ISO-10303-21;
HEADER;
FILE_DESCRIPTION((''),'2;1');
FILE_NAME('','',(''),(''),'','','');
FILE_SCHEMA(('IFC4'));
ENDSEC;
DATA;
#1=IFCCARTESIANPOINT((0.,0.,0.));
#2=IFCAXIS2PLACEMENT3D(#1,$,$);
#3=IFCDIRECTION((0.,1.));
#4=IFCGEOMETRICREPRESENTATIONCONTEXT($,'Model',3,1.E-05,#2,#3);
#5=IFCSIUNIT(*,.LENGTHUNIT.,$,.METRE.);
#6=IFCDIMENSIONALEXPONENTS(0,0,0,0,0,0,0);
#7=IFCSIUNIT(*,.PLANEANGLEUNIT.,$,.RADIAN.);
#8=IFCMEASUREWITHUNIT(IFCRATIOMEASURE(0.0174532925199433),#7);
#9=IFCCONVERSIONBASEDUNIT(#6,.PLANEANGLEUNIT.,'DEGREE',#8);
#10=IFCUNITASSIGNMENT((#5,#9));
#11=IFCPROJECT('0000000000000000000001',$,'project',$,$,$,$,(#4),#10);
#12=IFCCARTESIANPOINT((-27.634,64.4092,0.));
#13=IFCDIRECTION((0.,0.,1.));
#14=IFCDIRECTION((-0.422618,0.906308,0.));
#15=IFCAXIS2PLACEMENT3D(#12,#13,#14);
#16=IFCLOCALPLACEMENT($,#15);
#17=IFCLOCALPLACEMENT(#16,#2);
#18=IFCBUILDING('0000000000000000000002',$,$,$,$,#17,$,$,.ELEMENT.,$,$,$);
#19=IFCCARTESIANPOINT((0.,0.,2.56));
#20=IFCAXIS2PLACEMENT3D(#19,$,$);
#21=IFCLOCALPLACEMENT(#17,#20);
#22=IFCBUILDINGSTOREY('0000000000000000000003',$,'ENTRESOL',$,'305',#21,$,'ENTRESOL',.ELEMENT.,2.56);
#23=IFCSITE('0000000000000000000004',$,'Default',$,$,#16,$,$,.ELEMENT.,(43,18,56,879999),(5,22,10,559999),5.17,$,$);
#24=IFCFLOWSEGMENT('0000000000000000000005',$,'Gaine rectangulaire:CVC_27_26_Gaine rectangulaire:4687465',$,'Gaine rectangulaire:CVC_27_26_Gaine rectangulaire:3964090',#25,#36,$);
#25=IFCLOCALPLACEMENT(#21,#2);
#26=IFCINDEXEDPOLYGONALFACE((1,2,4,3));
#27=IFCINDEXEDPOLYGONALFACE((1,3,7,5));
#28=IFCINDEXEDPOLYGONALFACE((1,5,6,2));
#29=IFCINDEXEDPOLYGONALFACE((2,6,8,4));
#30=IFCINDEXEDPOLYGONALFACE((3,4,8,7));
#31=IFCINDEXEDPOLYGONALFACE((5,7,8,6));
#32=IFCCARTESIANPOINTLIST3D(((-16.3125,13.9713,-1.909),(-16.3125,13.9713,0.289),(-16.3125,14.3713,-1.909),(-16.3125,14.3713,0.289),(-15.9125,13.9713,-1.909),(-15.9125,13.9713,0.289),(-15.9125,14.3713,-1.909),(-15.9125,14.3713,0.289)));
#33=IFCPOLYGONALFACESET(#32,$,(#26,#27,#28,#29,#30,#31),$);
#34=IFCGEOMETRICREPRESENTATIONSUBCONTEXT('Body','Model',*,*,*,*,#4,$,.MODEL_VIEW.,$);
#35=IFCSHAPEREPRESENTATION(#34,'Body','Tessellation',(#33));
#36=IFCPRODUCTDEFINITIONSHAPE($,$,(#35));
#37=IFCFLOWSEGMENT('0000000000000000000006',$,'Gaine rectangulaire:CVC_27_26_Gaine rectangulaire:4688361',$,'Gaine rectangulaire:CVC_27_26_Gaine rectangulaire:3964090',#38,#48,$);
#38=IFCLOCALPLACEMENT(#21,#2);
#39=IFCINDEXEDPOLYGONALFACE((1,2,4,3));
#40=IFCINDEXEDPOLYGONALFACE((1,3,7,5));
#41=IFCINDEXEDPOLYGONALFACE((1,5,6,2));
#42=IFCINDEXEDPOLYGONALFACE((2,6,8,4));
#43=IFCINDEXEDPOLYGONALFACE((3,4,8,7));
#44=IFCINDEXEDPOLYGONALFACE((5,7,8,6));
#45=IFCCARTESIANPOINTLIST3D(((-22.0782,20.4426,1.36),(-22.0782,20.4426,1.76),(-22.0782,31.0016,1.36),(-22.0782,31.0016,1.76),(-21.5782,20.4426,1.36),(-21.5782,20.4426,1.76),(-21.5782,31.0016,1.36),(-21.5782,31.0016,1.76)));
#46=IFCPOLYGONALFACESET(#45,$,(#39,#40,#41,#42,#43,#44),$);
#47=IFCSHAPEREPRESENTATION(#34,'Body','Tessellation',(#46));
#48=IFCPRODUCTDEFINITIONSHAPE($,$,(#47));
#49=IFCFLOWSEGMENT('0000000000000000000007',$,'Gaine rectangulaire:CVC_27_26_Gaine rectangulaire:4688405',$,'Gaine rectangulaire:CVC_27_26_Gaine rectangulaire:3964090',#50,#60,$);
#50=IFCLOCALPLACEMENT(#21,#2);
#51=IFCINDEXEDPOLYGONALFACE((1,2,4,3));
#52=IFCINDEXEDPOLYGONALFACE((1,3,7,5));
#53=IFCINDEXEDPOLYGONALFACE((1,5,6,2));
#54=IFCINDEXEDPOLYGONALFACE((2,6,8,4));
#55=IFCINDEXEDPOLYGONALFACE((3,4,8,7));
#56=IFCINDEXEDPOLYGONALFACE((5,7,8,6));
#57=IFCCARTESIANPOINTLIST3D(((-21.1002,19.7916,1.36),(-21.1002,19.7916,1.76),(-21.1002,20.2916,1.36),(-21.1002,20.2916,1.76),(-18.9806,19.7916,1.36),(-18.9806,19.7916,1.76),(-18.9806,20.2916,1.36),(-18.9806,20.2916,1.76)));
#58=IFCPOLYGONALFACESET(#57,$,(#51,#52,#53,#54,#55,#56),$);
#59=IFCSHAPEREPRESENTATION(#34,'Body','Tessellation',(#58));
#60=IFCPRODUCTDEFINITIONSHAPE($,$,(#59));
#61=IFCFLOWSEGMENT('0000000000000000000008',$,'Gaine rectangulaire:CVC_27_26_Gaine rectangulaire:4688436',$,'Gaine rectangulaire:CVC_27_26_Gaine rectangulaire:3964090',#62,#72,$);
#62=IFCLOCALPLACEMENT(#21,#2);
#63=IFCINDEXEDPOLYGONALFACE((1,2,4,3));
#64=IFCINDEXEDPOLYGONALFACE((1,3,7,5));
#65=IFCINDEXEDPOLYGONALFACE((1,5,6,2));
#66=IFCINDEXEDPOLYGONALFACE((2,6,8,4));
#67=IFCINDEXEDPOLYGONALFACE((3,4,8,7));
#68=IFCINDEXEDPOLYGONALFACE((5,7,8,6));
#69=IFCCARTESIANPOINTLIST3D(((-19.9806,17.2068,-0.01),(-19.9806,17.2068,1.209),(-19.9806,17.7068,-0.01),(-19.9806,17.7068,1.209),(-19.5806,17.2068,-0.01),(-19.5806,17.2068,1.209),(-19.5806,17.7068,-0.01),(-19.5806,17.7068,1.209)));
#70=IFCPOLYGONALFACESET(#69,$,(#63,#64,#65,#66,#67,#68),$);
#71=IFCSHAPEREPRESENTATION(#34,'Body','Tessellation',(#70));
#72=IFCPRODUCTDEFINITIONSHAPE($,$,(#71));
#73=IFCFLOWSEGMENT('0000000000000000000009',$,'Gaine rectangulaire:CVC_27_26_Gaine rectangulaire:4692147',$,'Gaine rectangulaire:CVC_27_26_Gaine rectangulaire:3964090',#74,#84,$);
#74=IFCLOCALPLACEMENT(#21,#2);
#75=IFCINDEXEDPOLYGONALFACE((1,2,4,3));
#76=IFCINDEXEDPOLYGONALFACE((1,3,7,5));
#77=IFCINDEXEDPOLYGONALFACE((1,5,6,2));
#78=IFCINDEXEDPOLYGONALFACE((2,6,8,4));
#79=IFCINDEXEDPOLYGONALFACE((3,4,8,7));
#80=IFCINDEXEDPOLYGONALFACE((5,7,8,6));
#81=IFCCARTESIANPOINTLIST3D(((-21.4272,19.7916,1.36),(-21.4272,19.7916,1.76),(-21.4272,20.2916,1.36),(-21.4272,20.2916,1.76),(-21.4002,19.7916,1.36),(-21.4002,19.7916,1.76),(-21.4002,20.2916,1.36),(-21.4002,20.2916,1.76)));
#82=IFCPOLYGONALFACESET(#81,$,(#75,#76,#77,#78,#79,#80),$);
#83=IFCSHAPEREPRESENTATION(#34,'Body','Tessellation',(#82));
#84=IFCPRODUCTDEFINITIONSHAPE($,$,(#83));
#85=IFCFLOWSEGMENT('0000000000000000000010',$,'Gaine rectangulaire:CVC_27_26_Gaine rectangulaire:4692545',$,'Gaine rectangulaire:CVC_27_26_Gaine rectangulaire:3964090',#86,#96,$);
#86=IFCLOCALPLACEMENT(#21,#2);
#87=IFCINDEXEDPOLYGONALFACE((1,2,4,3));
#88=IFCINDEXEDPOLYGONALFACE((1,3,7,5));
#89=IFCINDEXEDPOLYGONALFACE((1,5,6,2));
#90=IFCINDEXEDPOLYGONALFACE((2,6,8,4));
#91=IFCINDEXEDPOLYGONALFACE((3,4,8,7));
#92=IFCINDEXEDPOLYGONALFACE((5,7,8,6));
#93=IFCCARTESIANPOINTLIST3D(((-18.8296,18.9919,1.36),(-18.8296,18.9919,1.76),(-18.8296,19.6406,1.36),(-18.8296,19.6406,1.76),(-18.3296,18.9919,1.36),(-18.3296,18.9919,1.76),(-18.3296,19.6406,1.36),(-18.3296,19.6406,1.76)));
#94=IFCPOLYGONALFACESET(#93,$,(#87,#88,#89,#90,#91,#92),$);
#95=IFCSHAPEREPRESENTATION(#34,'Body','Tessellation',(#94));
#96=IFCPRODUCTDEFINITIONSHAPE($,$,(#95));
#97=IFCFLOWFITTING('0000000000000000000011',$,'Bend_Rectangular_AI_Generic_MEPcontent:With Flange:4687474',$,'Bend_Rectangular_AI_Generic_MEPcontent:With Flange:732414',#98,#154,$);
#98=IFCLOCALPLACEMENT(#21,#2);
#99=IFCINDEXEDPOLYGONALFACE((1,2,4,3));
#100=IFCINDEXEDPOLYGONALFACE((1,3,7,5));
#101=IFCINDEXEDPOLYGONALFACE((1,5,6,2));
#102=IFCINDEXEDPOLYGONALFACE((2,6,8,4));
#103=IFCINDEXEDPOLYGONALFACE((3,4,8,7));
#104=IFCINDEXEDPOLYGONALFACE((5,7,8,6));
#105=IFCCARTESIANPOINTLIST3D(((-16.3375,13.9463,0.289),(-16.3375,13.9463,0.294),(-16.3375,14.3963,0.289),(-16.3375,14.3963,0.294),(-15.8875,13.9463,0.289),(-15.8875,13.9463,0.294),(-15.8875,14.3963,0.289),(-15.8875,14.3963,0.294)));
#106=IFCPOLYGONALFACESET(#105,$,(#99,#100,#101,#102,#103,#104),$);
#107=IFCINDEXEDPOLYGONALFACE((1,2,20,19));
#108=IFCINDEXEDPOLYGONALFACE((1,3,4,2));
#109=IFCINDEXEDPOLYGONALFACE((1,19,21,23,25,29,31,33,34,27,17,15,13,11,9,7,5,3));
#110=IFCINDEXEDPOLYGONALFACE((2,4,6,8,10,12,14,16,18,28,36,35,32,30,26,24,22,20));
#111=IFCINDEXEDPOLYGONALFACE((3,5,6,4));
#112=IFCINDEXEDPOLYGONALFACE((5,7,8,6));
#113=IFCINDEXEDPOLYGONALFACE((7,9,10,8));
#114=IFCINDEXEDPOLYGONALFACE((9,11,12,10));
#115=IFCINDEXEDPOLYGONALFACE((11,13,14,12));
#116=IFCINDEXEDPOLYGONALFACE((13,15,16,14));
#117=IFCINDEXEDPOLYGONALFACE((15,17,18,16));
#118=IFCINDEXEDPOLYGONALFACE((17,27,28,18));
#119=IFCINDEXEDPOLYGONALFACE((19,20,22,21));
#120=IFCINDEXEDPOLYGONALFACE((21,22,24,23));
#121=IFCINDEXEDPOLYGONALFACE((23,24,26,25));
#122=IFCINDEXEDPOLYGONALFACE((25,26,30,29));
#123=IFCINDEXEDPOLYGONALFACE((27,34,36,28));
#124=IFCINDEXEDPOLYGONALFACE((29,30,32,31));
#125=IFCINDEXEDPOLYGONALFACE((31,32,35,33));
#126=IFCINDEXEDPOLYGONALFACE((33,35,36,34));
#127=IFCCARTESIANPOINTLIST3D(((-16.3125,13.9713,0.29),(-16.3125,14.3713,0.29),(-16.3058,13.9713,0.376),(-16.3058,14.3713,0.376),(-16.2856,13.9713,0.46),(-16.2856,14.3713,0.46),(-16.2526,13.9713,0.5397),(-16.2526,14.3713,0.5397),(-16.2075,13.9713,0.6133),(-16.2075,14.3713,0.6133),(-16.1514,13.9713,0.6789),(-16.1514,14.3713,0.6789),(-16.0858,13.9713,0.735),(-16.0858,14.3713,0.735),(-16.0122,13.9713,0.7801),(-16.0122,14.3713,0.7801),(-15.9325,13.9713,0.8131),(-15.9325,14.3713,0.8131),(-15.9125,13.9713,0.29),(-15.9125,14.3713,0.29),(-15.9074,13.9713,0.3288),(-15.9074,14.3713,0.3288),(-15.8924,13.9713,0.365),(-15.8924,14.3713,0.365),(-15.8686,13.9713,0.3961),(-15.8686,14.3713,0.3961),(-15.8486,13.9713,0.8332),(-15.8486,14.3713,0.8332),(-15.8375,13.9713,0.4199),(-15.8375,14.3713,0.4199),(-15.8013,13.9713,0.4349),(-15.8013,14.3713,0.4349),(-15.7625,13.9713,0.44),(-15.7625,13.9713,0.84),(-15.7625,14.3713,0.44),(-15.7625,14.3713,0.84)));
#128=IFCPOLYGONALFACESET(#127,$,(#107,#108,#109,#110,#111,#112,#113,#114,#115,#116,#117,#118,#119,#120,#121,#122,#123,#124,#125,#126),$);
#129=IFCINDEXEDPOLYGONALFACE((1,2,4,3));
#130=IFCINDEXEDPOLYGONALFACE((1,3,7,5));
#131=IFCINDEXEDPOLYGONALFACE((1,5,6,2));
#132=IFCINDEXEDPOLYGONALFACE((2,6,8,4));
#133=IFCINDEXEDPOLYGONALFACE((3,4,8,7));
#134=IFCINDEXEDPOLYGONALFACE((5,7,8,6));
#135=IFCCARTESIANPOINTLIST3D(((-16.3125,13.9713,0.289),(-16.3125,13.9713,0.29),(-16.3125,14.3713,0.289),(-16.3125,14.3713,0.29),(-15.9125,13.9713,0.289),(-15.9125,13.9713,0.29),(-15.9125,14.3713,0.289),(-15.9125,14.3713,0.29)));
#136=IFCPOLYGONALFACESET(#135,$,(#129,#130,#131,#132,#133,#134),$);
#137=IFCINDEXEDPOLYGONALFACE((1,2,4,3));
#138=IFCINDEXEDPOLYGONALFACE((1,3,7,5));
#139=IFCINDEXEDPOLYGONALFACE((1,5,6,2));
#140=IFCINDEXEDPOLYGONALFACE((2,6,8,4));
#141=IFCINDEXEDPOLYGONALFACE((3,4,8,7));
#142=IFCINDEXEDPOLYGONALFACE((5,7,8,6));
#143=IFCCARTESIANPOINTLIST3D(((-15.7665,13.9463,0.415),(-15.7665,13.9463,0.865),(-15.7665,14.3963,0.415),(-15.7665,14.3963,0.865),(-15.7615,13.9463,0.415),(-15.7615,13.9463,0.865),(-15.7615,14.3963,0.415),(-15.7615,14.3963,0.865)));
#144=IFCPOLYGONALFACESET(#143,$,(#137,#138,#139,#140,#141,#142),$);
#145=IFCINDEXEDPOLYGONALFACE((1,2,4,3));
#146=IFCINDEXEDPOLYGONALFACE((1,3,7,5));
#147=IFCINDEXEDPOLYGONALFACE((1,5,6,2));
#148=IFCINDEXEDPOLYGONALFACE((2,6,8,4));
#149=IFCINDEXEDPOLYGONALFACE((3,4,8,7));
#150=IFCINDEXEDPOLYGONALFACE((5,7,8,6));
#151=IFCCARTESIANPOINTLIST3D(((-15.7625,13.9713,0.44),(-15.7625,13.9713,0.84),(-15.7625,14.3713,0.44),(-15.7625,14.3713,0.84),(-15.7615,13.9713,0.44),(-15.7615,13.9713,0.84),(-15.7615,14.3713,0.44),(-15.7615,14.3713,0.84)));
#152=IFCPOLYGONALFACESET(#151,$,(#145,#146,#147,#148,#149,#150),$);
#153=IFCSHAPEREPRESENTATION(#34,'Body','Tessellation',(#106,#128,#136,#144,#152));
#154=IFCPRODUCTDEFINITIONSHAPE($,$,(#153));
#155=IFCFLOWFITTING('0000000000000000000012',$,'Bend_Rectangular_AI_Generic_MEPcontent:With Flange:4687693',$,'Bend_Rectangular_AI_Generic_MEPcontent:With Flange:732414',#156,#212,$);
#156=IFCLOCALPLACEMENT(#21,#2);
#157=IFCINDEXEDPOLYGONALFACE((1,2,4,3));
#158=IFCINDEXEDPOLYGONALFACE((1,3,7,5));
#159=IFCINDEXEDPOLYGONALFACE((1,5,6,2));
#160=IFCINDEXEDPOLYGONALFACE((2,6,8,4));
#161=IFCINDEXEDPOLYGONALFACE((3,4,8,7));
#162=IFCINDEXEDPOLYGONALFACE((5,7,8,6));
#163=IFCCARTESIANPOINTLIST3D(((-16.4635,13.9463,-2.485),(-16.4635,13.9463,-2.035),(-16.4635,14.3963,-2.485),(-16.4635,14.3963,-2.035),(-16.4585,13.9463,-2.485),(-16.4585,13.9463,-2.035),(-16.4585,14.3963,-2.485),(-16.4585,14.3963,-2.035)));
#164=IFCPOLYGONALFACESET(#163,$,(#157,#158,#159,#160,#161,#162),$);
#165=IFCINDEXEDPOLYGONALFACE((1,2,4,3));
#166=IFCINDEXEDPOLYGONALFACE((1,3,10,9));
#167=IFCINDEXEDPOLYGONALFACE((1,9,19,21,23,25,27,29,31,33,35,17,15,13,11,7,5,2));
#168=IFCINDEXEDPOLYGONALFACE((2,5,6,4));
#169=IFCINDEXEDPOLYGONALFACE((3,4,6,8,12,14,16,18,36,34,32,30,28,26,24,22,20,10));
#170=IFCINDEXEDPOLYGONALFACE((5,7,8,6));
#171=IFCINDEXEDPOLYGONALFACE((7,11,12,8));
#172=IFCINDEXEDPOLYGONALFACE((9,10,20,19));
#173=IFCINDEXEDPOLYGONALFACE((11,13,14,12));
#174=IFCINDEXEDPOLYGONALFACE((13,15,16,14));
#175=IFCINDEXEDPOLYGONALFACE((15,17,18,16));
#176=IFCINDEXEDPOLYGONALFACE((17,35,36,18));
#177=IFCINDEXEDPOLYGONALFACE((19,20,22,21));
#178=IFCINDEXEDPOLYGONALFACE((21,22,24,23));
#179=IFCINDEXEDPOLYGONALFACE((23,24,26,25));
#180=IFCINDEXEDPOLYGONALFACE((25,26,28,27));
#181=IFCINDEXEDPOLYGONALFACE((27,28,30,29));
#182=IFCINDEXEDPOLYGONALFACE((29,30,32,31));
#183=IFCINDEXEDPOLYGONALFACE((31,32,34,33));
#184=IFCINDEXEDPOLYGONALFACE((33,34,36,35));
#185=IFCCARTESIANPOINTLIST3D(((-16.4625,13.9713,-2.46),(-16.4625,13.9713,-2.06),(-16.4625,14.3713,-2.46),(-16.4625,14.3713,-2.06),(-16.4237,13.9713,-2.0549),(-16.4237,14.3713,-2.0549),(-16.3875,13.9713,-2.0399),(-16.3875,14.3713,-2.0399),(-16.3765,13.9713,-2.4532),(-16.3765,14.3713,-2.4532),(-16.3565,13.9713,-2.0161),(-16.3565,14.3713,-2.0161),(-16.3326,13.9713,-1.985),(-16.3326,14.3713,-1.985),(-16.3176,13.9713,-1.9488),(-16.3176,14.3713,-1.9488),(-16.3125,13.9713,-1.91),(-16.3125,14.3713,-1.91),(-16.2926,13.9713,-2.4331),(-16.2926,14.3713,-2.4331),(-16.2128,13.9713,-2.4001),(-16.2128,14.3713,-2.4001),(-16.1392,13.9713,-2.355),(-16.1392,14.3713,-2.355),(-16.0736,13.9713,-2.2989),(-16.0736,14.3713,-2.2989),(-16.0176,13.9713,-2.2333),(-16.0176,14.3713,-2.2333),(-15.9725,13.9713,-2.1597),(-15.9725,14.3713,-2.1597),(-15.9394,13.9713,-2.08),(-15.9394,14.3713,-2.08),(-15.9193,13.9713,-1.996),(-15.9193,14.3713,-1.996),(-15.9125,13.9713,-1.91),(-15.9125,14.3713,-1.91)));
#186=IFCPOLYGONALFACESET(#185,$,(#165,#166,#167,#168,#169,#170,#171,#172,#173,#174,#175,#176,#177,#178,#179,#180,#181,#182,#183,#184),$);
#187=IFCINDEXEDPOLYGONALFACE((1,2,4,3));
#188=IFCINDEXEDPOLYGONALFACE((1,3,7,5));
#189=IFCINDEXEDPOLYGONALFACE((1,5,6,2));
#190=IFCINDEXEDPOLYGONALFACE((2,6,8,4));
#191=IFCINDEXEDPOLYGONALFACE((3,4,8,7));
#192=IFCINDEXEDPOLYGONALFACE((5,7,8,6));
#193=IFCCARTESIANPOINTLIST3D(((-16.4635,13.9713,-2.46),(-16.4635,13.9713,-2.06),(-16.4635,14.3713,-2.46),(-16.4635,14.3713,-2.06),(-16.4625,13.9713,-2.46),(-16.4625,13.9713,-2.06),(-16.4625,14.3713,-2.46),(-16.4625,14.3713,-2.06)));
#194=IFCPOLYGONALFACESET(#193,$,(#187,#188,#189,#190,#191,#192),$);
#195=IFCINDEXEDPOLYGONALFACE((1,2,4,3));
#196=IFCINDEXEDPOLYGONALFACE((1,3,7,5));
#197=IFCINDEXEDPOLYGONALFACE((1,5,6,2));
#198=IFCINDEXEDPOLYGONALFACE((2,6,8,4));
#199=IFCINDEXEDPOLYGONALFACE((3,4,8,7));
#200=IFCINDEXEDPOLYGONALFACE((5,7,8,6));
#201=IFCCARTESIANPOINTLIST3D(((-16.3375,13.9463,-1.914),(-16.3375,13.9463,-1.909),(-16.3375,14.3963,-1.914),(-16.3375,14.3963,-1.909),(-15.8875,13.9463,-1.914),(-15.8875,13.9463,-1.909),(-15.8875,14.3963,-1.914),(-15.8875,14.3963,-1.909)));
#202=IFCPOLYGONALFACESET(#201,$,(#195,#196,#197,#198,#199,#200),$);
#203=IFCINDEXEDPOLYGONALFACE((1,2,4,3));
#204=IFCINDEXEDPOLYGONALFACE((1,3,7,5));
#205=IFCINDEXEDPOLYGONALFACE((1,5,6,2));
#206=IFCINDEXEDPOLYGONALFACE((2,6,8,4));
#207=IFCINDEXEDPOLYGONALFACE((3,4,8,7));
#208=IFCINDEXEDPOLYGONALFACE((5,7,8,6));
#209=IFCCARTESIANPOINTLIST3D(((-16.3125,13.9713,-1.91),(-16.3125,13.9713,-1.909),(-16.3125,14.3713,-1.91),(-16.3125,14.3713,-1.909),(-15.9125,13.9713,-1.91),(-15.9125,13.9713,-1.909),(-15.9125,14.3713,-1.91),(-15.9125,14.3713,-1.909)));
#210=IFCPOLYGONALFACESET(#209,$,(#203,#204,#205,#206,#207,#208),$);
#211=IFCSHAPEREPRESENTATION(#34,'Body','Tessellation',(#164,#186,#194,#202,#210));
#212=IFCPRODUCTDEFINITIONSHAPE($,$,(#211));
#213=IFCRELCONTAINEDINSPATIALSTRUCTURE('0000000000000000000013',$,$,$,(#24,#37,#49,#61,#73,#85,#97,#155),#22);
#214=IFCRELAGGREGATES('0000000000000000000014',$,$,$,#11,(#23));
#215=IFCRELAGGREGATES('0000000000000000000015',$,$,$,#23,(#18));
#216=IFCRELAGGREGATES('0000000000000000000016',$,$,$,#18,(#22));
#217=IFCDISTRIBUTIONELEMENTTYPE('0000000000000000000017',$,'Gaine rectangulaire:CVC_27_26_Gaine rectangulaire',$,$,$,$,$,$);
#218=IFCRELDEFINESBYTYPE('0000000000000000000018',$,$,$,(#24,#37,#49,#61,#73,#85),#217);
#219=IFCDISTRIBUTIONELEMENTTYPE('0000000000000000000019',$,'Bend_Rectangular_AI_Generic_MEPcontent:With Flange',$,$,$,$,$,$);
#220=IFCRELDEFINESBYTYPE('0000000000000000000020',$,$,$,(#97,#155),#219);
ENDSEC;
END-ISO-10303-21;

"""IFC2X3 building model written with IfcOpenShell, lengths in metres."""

from ifc_helpers import new_model, entity, si_unit, converted_unit, direction, frame, frame_2d, origin, origin_2d_with_axis, place, context, subcontext, project, spatial, polyline, circle_curve, parameter, trimmed, segment, composite_curve, rectangle, outline, extrude, source, transform, mapped, type_object, type_shapes, element, save


model = new_model("IFC2X3")

# Units and contexts
model_context = context("Model", 3, precision=1e-05, world=origin(), true_north=direction((0.0, 1.0)))
body_context = subcontext(model_context, "Body", "Model", "MODEL_VIEW")
ifc_project = project(units=[si_unit("LENGTHUNIT", "METRE"), converted_unit("PLANEANGLEUNIT", "DEGREE", entity("IfcRatioMeasure", 0.0174532925199433), si_unit("PLANEANGLEUNIT", "RADIAN"), dimensions=[0, 0, 0, 0, 0, 0, 0])], contexts=[model_context])

# Site, building, storey
site_placement = place(None, frame((-27.634, 64.4092, 0.0), z_axis=(0.0, 0.0, 1.0), x_axis=(-0.422618, 0.906308, 0.0)))
site = spatial("IfcSite", under=ifc_project, at=site_placement, Name="Default", CompositionType="ELEMENT", RefLatitude=(43, 18, 56, 879999), RefLongitude=(5, 22, 10, 559999), RefElevation=5.17)
building_placement = place(site_placement, origin())
building = spatial("IfcBuilding", under=site, at=building_placement, CompositionType="ELEMENT")
storey_placement = place(building_placement, frame((0.0, 0.0, 2.56)))
storey = spatial("IfcBuildingStorey", under=building, at=storey_placement, Name="ENTRESOL", ObjectType="305", LongName="ENTRESOL", CompositionType="ELEMENT", Elevation=2.56)

# Flow segments
distribution_element_type_1 = type_object("IfcDistributionElementType", Name="Gaine rectangulaire:CVC_27_26_Gaine rectangulaire")
flow_segment_1_placement = place(storey_placement, origin())
element("IfcFlowSegment", 1, at=flow_segment_1_placement, inside=storey, type_object=distribution_element_type_1, Name="Gaine rectangulaire:CVC_27_26_Gaine rectangulaire:4687465", ObjectType="Gaine rectangulaire:CVC_27_26_Gaine rectangulaire:3964090", context=body_context, shape_type="SweptSolid", body=[
    extrude(rectangle(XDim=0.4, YDim=0.4, at=origin_2d_with_axis()), frame((-16.1125, 14.1713, -1.909), z_axis=(0.0, -0.000001, 1.0), x_axis=(-1.0, 0.0, 0.0)), (0.0, 0.0, 1.0), 2.198),
])
flow_segment_2_placement = place(storey_placement, origin())
element("IfcFlowSegment", 2, at=flow_segment_2_placement, inside=storey, type_object=distribution_element_type_1, Name="Gaine rectangulaire:CVC_27_26_Gaine rectangulaire:4688361", ObjectType="Gaine rectangulaire:CVC_27_26_Gaine rectangulaire:3964090", context=body_context, shape_type="SweptSolid", body=[
    extrude(rectangle(XDim=10.559, YDim=0.5, at=frame_2d((0.0, 0.0), x_axis=(1.0, 0.0))), frame((-21.8282, 25.7221, 1.36), z_axis=(0.0, 0.0, 1.0), x_axis=(0.0, 1.0, 0.0)), (0.0, 0.0, 1.0), 0.4),
])
flow_segment_3_placement = place(storey_placement, origin())
element("IfcFlowSegment", 3, at=flow_segment_3_placement, inside=storey, type_object=distribution_element_type_1, Name="Gaine rectangulaire:CVC_27_26_Gaine rectangulaire:4688405", ObjectType="Gaine rectangulaire:CVC_27_26_Gaine rectangulaire:3964090", context=body_context, shape_type="SweptSolid", body=[
    extrude(rectangle(XDim=2.1196, YDim=0.5, at=frame_2d((0.0, 0.0), x_axis=(1.0, 0.0))), frame((-20.0404, 20.0416, 1.36)), (0.0, 0.0, 1.0), 0.4),
])
flow_segment_4_placement = place(storey_placement, origin())
element("IfcFlowSegment", 4, at=flow_segment_4_placement, inside=storey, type_object=distribution_element_type_1, Name="Gaine rectangulaire:CVC_27_26_Gaine rectangulaire:4688436", ObjectType="Gaine rectangulaire:CVC_27_26_Gaine rectangulaire:3964090", context=body_context, shape_type="SweptSolid", body=[
    extrude(rectangle(XDim=0.4, YDim=0.5, at=origin_2d_with_axis()), frame((-19.7806, 17.4568, -0.01), z_axis=(0.0, 0.0, 1.0), x_axis=(-1.0, 0.0, 0.0)), (0.0, 0.0, 1.0), 1.219),
])
flow_segment_5_placement = place(storey_placement, origin())
element("IfcFlowSegment", 5, at=flow_segment_5_placement, inside=storey, type_object=distribution_element_type_1, Name="Gaine rectangulaire:CVC_27_26_Gaine rectangulaire:4692147", ObjectType="Gaine rectangulaire:CVC_27_26_Gaine rectangulaire:3964090", context=body_context, shape_type="SweptSolid", body=[
    extrude(rectangle(XDim=0.027, YDim=0.5, at=frame_2d((0.0, 0.0), x_axis=(1.0, 0.0))), frame((-21.4137, 20.0416, 1.36)), (0.0, 0.0, 1.0), 0.4),
])
flow_segment_6_placement = place(storey_placement, origin())
element("IfcFlowSegment", 6, at=flow_segment_6_placement, inside=storey, type_object=distribution_element_type_1, Name="Gaine rectangulaire:CVC_27_26_Gaine rectangulaire:4692545", ObjectType="Gaine rectangulaire:CVC_27_26_Gaine rectangulaire:3964090", context=body_context, shape_type="SweptSolid", body=[
    extrude(rectangle(XDim=0.6487, YDim=0.5, at=frame_2d((0.0, 0.0), x_axis=(1.0, 0.0))), frame((-18.5796, 19.3163, 1.36), z_axis=(0.0, 0.0, 1.0), x_axis=(0.0, -1.0, 0.0)), (0.0, 0.0, 1.0), 0.4),
])

# Flow fittings
distribution_element_type_2 = type_object("IfcDistributionElementType", Name="Bend_Rectangular_AI_Generic_MEPcontent:With Flange")
shared_shape_1 = source(origin(), body_context, "Body", "SweptSolid", [
    extrude(rectangle(XDim=0.005, YDim=0.45, at=frame_2d((0.0, 0.0), x_axis=(1.0, 0.0))), frame((0.0, 0.3485, -0.225), z_axis=(0.0, 0.0, 1.0), x_axis=(0.0, -1.0, 0.0)), (0.0, 0.0, 1.0), 0.45),
    extrude(outline(composite_curve([segment(trimmed(circle_curve(frame_2d((-0.175, 0.175), x_axis=(1.0, 0.0)), 0.55), [parameter(270.0)], [parameter(360.0)], True, "PARAMETER"), True, "CONTINUOUS"), segment(polyline([(0.375, 0.175), (-0.025, 0.175)]), True, "CONTINUOUS"), segment(trimmed(circle_curve(frame_2d((-0.175, 0.175), x_axis=(1.0, 0.0)), 0.15), [parameter(270.0)], [parameter(0.0)], True, "PARAMETER"), False, "CONTINUOUS"), segment(polyline([(-0.175, 0.025), (-0.175, -0.375)]), True, "CONTINUOUS")], self_intersect=False)), frame((-0.175, 0.175, -0.2)), (0.0, 0.0, 1.0), 0.4),
    extrude(rectangle(XDim=0.001, YDim=0.4, at=frame_2d((0.0, 0.0), x_axis=(1.0, 0.0))), frame((0.0, 0.3505, -0.2), z_axis=(0.0, 0.0, 1.0), x_axis=(0.0, 1.0, 0.0)), (0.0, 0.0, 1.0), 0.4),
    extrude(rectangle(XDim=0.005, YDim=0.45, at=frame_2d((0.0, 0.0), x_axis=(1.0, 0.0))), frame((-0.3485, 0.0, -0.225)), (0.0, 0.0, 1.0), 0.45),
    extrude(rectangle(XDim=0.001, YDim=0.4, at=frame_2d((0.0, 0.0), x_axis=(1.0, 0.0))), frame((-0.3505, 0.0, -0.2), z_axis=(0.0, 0.0, 1.0), x_axis=(-1.0, 0.0, 0.0)), (0.0, 0.0, 1.0), 0.4),
])
type_shapes(distribution_element_type_2, [shared_shape_1])
for number, where, z_axis, x_axis, name in (
    (7, (-16.1125, 14.1713, 0.64), (0.0, -1.0, -0.000002), (-1.0, 0.0, 0.0), "Bend_Rectangular_AI_Generic_MEPcontent:With Flange:4687474"),
    (8, (-16.1125, 14.1713, -2.26), (0.0, 1.0, 0.000001), (0.0, 0.000001, -1.0), "Bend_Rectangular_AI_Generic_MEPcontent:With Flange:4687693"),
):
    element("IfcFlowFitting", number, at=place(storey_placement, frame(where, z_axis=z_axis, x_axis=x_axis)), inside=storey, type_object=distribution_element_type_2, Name=name, ObjectType="Bend_Rectangular_AI_Generic_MEPcontent:With Flange:732414", context=body_context, shape_type="MappedRepresentation", body=[
        mapped(shared_shape_1, transform((0.0, 0.0, 0.0), scale=1.0)),
    ])

save(model, "model.ifc")
